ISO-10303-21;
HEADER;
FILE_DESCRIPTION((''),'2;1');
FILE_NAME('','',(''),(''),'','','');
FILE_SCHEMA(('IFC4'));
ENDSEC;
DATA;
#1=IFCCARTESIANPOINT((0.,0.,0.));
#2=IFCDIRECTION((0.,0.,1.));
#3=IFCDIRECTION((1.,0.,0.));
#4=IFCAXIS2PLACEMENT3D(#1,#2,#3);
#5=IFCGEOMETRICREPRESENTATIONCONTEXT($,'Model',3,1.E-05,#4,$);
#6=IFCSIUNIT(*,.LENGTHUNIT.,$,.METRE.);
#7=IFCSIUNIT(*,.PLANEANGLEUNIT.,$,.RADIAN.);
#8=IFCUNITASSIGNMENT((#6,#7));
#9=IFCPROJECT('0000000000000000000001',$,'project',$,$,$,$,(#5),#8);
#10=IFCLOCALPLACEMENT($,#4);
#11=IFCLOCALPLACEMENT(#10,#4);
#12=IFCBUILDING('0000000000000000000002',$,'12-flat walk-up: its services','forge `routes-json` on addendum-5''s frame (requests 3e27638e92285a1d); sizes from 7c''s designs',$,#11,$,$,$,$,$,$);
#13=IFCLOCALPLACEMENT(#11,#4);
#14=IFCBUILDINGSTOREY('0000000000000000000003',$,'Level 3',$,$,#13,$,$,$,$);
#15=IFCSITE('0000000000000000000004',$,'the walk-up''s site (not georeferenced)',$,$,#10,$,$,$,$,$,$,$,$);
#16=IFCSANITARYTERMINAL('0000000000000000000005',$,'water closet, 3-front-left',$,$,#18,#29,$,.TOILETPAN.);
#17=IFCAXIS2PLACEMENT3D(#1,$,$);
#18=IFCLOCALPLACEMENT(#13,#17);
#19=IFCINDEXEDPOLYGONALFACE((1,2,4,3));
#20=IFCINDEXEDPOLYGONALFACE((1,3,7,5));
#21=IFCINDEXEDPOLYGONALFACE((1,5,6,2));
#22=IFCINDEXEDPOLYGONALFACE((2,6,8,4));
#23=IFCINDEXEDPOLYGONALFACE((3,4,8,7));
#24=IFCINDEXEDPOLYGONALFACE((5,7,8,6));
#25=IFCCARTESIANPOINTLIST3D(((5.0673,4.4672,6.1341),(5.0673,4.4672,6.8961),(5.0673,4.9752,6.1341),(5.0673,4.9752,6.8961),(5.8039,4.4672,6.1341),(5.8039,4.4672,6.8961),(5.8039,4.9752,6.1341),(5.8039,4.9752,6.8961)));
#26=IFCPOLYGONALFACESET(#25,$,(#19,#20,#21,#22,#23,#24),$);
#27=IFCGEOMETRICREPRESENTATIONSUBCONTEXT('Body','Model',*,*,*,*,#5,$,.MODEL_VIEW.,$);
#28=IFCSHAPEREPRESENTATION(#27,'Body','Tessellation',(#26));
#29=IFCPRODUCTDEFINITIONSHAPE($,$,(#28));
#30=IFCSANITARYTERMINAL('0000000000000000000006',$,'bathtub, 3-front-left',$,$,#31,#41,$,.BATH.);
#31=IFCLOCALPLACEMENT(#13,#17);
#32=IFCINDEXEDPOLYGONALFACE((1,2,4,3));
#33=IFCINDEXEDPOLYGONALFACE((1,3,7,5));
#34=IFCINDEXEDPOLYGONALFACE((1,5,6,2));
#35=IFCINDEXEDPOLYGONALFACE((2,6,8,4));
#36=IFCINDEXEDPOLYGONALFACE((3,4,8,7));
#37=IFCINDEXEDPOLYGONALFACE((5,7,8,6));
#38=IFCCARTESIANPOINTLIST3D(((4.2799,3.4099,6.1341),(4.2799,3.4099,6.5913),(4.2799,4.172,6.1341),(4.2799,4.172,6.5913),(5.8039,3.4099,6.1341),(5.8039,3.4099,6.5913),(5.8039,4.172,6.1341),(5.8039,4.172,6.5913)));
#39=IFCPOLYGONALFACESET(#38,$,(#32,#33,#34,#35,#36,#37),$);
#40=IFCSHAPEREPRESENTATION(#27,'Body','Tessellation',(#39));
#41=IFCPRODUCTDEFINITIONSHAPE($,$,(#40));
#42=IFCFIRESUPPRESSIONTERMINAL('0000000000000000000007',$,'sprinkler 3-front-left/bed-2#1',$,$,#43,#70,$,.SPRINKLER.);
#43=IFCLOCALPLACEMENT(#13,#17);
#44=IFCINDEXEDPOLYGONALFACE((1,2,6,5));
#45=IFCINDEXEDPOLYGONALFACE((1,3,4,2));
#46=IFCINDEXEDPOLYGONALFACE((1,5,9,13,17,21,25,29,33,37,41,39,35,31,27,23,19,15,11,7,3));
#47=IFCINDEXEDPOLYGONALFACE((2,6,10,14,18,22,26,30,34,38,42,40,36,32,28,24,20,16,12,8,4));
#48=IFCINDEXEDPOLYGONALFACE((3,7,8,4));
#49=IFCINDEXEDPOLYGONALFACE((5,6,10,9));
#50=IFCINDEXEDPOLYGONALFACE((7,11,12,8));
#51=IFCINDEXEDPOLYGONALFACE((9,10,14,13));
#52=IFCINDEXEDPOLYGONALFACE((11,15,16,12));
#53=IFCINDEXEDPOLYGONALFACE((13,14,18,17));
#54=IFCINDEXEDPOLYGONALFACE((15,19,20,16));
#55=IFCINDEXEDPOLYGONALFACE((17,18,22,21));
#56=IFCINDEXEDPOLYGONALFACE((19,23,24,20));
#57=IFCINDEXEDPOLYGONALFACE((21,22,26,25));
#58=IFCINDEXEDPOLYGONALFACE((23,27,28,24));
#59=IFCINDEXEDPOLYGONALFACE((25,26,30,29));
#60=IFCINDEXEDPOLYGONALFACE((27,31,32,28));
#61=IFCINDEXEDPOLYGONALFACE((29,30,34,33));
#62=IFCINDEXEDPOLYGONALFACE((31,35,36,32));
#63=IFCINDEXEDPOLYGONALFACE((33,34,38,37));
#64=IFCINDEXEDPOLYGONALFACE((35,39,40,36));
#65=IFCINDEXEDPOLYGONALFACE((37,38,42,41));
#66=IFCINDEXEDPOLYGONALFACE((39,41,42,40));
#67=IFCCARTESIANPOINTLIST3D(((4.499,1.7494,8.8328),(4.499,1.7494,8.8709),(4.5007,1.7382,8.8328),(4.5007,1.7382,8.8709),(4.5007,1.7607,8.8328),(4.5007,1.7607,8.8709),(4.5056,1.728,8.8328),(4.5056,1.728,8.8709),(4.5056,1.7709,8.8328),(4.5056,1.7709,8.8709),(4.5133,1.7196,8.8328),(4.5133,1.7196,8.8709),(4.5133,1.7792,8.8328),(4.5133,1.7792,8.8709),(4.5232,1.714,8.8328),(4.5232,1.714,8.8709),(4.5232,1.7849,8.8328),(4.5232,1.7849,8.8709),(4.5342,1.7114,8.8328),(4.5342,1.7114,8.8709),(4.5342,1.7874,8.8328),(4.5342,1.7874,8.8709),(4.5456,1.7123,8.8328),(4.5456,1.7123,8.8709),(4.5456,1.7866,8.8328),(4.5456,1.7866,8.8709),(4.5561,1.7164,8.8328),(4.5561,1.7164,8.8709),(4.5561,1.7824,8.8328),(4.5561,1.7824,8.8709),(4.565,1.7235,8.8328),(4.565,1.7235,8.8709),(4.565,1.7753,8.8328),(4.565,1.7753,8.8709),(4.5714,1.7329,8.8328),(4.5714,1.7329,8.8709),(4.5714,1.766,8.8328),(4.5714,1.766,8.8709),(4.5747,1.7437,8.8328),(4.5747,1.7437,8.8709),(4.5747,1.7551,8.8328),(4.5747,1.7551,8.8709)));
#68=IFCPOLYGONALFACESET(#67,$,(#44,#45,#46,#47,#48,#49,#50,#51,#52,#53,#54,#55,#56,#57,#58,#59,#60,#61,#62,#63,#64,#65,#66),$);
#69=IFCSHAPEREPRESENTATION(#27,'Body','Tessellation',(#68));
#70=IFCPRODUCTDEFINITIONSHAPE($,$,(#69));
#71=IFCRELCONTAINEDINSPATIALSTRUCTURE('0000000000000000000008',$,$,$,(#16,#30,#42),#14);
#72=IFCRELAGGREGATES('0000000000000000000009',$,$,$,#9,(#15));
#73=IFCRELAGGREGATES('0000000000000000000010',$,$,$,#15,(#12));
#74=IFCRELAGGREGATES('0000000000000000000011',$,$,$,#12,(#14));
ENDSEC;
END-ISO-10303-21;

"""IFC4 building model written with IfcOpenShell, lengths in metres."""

from ifc_helpers import new_model, entity, si_unit, frame, frame_2d, origin, origin_with_axes, place, context, subcontext, project, spatial, rectangle, extrude, element, save


model = new_model("IFC4")

# Units and contexts
model_context = context("Model", 3, precision=1e-05, world=origin_with_axes())
body_context = subcontext(model_context, "Body", "Model", "MODEL_VIEW")
ifc_project = project(units=[si_unit("LENGTHUNIT", "METRE"), si_unit("PLANEANGLEUNIT", "RADIAN")], contexts=[model_context])

# Site, building, storey
site_placement = place(None, origin_with_axes())
site = spatial("IfcSite", under=ifc_project, at=site_placement, Name="the walk-up's site (not georeferenced)")
building_placement = place(site_placement, origin_with_axes())
building = spatial("IfcBuilding", under=site, at=building_placement, Name="12-flat walk-up: its services", Description="forge `routes-json` on addendum-5's frame (requests 3e27638e92285a1d); sizes from 7c's designs")
storey_placement = place(building_placement, origin_with_axes())
storey = spatial("IfcBuildingStorey", under=building, at=storey_placement, Name="Level 3")

# Sanitary terminals
sanitary_terminal_1_placement = place(storey_placement, frame((5.0673, 4.4672, 6.1341), z_axis=(0.0, 0.0, 1.0), x_axis=(1.0, 0.0, 0.0)))
element("IfcSanitaryTerminal", 1, at=sanitary_terminal_1_placement, inside=storey, Name="water closet, 3-front-left", PredefinedType="TOILETPAN", context=body_context, shape_type="SweptSolid", body=[
    extrude(rectangle(XDim=0.7366, YDim=0.508, at=frame_2d((0.3683, 0.254))), origin(), (0.0, 0.0, 1.0), 0.762),
])
sanitary_terminal_2_placement = place(storey_placement, frame((4.2799, 3.4099, 6.1341), z_axis=(0.0, 0.0, 1.0), x_axis=(1.0, 0.0, 0.0)))
element("IfcSanitaryTerminal", 2, at=sanitary_terminal_2_placement, inside=storey, Name="bathtub, 3-front-left", PredefinedType="BATH", context=body_context, shape_type="SweptSolid", body=[
    extrude(rectangle(XDim=1.524, YDim=0.762, at=frame_2d((0.762, 0.381))), origin(), (0.0, 0.0, 1.0), 0.4572),
])

# Fire suppression terminal
fire_suppression_terminal_placement = place(storey_placement, frame((4.5371, 1.7494, 8.8709), z_axis=(0.0, 0.0, 1.0), x_axis=(1.0, 0.0, 0.0)))
element("IfcFireSuppressionTerminal", 3, at=fire_suppression_terminal_placement, inside=storey, Name="sprinkler 3-front-left/bed-2#1", PredefinedType="SPRINKLER", context=body_context, shape_type="AdvancedSweptSolid", body=[
    entity("IfcSweptDiskSolid", entity("IfcPolyline", [entity("IfcCartesianPoint", [0.0, 0.0, 0.0]), entity("IfcCartesianPoint", [0.0, 0.0, -0.0381])]), 0.0381),
])

save(model, "model.ifc")
